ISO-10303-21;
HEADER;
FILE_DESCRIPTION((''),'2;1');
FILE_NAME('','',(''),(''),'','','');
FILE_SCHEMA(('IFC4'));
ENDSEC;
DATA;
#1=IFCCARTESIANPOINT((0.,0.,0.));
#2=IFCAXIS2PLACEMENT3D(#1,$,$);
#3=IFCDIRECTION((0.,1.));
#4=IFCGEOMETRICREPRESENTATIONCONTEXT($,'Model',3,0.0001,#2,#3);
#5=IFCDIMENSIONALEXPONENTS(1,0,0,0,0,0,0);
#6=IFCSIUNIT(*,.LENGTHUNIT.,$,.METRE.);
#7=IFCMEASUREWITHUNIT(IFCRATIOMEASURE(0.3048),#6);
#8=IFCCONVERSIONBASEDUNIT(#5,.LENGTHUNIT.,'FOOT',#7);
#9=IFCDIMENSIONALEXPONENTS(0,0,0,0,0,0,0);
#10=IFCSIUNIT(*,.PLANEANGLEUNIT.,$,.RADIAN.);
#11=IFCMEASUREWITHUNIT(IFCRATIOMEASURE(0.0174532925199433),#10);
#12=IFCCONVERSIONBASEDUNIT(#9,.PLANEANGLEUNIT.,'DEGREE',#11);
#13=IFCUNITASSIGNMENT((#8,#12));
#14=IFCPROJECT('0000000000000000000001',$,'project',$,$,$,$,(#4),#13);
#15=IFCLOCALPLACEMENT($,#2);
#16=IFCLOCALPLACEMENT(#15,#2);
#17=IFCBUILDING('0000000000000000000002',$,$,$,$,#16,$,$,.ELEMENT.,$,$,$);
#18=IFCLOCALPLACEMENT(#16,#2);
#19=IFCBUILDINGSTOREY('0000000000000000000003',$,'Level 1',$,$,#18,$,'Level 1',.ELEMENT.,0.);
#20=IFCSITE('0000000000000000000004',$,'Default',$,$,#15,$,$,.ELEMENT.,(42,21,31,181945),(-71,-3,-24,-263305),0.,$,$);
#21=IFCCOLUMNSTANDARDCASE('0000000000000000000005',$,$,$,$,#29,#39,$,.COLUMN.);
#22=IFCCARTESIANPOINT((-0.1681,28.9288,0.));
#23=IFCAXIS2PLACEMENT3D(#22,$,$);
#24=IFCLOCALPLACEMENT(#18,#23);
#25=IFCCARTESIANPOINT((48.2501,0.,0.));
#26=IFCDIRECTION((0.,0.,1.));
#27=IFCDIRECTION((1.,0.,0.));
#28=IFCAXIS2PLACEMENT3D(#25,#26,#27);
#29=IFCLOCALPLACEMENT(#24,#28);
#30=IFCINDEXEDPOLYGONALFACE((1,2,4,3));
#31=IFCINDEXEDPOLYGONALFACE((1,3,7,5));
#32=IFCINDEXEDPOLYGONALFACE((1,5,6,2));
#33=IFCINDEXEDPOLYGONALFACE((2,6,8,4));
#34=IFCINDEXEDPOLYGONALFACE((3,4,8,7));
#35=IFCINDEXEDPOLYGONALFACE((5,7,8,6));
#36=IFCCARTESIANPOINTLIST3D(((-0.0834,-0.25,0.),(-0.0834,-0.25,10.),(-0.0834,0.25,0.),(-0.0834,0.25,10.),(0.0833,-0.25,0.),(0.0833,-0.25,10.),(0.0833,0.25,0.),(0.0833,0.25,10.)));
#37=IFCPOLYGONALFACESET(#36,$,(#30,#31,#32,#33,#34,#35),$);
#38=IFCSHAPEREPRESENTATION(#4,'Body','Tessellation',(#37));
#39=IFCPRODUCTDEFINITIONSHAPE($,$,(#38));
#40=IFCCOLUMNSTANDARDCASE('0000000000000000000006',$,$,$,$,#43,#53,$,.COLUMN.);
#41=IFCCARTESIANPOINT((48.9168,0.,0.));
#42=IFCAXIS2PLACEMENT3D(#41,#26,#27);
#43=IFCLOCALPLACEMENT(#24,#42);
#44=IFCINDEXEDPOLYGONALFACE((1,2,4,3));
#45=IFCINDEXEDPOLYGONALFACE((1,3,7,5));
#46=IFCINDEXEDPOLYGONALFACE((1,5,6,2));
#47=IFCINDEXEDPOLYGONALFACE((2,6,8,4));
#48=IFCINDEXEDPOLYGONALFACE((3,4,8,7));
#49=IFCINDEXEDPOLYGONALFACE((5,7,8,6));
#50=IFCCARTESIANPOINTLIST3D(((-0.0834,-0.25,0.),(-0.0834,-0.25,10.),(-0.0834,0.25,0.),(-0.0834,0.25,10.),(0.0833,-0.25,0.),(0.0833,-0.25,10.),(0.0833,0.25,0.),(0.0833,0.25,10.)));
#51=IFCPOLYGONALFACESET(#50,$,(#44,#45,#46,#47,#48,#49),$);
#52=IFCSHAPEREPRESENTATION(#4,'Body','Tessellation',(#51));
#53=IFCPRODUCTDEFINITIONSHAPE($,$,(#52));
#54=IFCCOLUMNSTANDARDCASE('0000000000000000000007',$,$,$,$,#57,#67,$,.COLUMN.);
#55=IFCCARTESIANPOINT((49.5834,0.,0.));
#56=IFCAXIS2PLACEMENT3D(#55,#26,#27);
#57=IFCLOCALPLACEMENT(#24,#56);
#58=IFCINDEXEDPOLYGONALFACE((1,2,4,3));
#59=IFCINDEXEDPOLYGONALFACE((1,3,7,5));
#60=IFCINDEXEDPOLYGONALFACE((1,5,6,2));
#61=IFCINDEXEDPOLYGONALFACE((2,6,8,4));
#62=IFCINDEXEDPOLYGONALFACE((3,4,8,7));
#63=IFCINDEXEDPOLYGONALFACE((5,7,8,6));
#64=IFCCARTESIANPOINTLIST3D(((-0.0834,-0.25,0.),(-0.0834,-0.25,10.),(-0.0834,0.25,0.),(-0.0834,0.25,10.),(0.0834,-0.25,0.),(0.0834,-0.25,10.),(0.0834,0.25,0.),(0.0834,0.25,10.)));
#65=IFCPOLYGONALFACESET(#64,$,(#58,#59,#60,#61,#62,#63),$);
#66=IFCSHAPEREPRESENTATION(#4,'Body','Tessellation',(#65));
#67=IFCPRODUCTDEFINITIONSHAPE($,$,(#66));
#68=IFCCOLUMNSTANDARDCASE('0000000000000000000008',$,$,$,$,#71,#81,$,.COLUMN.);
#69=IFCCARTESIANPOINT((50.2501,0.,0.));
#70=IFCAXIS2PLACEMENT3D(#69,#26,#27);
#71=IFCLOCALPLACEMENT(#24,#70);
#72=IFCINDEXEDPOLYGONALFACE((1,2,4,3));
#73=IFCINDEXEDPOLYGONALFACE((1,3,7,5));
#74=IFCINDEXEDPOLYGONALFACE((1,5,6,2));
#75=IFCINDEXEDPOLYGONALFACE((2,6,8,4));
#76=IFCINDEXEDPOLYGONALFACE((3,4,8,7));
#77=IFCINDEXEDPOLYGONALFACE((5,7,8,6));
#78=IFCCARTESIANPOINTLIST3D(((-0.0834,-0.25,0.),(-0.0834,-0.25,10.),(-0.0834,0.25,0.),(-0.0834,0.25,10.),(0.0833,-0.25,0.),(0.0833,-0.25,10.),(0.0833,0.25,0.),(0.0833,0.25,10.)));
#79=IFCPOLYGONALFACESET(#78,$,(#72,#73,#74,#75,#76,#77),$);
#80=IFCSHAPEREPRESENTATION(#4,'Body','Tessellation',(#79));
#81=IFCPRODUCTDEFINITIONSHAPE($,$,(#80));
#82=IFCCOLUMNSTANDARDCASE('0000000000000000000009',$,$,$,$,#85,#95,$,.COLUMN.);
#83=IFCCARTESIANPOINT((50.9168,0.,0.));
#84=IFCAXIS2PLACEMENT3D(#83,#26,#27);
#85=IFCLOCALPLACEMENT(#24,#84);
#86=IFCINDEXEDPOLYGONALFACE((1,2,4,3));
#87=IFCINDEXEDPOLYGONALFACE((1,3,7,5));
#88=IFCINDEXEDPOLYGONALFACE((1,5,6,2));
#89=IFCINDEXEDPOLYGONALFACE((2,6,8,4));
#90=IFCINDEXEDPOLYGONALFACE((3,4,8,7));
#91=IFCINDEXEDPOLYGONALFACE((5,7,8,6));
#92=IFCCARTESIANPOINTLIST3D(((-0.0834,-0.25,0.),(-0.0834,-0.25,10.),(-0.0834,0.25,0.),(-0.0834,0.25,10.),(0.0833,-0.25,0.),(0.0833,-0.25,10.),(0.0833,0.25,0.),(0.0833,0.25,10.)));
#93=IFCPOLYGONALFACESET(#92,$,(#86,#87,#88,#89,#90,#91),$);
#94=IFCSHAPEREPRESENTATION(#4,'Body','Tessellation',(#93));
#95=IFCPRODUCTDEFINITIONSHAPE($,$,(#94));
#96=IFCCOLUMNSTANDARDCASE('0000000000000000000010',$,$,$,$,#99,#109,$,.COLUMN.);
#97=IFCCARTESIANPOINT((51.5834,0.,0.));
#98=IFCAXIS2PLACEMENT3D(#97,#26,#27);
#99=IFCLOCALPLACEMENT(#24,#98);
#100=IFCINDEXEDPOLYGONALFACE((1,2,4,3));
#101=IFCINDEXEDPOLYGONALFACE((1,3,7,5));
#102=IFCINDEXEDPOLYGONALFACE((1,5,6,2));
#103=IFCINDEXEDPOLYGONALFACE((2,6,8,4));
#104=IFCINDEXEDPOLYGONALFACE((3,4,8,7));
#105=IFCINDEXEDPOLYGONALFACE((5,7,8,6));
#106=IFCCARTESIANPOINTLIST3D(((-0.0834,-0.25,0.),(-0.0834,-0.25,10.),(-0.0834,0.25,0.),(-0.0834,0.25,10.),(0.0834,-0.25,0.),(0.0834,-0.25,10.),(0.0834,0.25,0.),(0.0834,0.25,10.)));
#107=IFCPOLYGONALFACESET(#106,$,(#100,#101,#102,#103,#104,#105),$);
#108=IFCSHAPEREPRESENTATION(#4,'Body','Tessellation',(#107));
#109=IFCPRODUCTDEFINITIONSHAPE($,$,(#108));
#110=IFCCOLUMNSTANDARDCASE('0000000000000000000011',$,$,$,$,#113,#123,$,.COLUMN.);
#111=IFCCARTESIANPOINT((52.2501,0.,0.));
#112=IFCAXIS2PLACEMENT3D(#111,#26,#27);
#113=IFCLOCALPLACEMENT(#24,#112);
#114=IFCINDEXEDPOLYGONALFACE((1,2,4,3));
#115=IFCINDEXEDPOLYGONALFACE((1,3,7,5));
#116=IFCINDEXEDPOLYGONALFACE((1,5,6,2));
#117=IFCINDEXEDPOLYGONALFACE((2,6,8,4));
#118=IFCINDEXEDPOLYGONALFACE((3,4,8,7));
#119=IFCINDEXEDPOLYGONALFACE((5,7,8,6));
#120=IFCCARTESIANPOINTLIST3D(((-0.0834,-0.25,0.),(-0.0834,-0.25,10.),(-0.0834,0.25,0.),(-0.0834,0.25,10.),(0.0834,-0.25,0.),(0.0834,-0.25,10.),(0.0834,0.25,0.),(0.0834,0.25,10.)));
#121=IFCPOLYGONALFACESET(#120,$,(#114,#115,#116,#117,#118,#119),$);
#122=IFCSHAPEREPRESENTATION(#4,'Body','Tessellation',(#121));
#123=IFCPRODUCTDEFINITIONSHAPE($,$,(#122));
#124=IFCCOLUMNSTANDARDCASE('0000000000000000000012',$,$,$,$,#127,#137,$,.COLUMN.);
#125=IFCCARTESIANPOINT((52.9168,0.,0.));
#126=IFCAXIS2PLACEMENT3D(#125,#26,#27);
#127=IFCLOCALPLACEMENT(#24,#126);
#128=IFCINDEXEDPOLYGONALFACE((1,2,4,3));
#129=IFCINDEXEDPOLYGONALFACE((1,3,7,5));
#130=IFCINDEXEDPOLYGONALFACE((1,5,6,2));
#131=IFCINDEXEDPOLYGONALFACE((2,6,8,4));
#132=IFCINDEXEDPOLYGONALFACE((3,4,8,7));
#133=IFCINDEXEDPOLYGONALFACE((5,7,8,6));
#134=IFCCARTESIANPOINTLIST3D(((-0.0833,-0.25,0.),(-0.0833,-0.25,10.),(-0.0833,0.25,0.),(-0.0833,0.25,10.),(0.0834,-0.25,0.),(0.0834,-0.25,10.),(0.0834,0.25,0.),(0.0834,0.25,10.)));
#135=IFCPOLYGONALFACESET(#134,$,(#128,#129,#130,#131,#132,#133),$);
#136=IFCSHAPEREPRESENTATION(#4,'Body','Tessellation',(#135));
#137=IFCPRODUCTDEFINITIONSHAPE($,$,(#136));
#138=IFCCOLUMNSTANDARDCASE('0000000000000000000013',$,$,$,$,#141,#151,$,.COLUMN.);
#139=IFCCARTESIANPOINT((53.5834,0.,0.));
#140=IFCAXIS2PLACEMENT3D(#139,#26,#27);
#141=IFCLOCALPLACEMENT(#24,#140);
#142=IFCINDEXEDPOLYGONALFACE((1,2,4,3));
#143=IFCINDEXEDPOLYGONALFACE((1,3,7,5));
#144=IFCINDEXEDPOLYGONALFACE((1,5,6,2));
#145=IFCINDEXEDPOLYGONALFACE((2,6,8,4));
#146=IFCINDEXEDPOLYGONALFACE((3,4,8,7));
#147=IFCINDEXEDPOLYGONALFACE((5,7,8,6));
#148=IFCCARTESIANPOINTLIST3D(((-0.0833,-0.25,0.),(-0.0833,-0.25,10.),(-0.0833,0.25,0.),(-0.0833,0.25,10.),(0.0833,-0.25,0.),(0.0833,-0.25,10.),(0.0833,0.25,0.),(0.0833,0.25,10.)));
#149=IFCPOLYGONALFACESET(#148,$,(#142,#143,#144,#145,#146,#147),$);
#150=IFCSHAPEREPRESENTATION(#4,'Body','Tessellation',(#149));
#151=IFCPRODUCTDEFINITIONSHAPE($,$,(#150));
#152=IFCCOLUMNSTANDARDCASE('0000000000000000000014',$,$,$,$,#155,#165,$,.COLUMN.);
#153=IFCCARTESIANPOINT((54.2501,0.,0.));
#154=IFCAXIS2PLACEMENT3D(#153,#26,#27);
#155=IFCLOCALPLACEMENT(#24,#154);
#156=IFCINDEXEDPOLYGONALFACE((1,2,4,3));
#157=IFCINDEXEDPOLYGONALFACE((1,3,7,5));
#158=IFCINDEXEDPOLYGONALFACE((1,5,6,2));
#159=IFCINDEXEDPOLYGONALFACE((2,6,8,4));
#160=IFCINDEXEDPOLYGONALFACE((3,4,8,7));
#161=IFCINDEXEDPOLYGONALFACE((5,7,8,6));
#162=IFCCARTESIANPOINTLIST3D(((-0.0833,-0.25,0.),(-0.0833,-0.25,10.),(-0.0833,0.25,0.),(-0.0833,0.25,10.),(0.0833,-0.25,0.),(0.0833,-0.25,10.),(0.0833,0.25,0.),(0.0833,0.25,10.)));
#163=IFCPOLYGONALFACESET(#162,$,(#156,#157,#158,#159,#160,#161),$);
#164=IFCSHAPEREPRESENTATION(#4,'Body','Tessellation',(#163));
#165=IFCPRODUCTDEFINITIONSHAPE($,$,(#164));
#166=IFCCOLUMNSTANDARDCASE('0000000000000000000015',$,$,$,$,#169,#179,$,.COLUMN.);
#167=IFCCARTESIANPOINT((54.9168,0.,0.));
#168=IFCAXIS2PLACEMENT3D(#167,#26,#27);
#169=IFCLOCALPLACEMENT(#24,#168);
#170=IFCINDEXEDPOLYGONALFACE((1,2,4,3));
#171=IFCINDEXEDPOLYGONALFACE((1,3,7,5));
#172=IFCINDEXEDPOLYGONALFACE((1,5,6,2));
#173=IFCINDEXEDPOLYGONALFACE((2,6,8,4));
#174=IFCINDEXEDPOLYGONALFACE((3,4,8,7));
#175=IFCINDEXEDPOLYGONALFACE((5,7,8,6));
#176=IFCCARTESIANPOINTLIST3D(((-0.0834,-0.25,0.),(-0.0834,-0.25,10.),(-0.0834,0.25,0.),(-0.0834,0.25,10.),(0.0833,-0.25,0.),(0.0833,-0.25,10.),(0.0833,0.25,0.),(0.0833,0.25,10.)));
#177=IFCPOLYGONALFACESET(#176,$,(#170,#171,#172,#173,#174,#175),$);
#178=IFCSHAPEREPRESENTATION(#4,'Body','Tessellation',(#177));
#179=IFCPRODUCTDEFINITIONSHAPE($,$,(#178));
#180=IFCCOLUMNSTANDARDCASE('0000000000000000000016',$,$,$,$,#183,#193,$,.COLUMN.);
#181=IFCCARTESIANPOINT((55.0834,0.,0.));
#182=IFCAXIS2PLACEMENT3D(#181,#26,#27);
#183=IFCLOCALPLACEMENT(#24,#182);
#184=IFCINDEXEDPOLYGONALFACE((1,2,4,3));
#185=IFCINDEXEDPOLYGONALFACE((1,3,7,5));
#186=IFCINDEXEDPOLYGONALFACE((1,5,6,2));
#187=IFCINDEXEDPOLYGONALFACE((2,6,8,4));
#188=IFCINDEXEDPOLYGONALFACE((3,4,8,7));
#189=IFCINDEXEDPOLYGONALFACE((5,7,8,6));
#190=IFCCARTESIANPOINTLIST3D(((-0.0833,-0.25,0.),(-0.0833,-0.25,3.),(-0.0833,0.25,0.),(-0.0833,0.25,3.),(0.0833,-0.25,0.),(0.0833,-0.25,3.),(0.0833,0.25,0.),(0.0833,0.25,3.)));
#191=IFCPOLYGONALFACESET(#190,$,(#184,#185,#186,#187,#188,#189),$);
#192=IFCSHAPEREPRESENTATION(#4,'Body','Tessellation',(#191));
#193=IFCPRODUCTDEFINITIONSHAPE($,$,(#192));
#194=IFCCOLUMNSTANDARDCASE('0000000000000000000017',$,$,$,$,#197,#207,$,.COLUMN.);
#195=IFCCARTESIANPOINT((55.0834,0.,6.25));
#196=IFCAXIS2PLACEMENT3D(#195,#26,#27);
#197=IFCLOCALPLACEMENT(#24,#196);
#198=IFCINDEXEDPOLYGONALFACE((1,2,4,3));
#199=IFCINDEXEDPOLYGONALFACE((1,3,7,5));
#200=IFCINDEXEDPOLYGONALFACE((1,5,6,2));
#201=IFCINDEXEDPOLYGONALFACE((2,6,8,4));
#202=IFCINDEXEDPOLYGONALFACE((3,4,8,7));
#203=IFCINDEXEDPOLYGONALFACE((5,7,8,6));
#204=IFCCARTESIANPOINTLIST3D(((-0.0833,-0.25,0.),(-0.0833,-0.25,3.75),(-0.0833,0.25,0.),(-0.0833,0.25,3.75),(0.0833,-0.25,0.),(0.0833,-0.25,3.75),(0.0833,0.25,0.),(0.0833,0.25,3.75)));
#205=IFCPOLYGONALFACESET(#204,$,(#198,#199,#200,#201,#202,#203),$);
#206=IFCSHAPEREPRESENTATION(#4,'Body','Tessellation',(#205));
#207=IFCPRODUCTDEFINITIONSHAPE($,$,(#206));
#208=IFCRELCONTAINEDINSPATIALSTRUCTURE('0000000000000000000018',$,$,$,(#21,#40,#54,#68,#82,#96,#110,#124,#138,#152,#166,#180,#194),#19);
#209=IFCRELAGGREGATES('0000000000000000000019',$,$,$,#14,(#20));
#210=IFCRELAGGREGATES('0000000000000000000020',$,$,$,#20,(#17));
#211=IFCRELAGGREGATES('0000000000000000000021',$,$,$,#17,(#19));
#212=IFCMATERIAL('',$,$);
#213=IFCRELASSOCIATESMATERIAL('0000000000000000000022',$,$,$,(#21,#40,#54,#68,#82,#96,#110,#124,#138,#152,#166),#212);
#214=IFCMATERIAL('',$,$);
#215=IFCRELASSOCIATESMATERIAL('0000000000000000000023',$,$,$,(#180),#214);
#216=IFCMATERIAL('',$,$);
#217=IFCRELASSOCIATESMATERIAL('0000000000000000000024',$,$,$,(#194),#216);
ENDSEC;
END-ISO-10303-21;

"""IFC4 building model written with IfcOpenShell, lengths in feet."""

from ifc_helpers import new_model, entity, si_unit, converted_unit, direction, frame, origin, place, context, project, spatial, rectangle, extrude, material, element, save


model = new_model("IFC4")

# Units and contexts
model_context = context("Model", 3, precision=0.0001, world=origin(), true_north=direction((0.0, 1.0)))
ifc_project = project(units=[converted_unit("LENGTHUNIT", "FOOT", entity("IfcRatioMeasure", 0.3048), si_unit("LENGTHUNIT", "METRE"), dimensions=[1, 0, 0, 0, 0, 0, 0]), converted_unit("PLANEANGLEUNIT", "DEGREE", entity("IfcRatioMeasure", 0.0174532925199433), si_unit("PLANEANGLEUNIT", "RADIAN"), dimensions=[0, 0, 0, 0, 0, 0, 0])], contexts=[model_context])

# Site, building, storey
site_placement = place(None, origin())
site = spatial("IfcSite", under=ifc_project, at=site_placement, Name="Default", CompositionType="ELEMENT", RefLatitude=(42, 21, 31, 181945), RefLongitude=(-71, -3, -24, -263305), RefElevation=0.0)
building_placement = place(site_placement, origin())
building = spatial("IfcBuilding", under=site, at=building_placement, CompositionType="ELEMENT")
storey_placement = place(building_placement, origin())
storey = spatial("IfcBuildingStorey", under=building, at=storey_placement, Name="Level 1", LongName="Level 1", CompositionType="ELEMENT", Elevation=0.0)

# Columns
ifc_material_1 = material(Name="")
placement = place(storey_placement, frame((-0.1681, 28.9288, 0.0)))
for number, where, z_axis, x_axis in (
    (1, (48.2501, 0.0, 0.0), (0.0, 0.0, 1.0), (1.0, 0.0, 0.0)),
    (2, (48.9168, 0.0, 0.0), (0.0, 0.0, 1.0), (1.0, 0.0, 0.0)),
    (3, (49.5834, 0.0, 0.0), (0.0, 0.0, 1.0), (1.0, 0.0, 0.0)),
    (4, (50.2501, 0.0, 0.0), (0.0, 0.0, 1.0), (1.0, 0.0, 0.0)),
    (5, (50.9168, 0.0, 0.0), (0.0, 0.0, 1.0), (1.0, 0.0, 0.0)),
    (6, (51.5834, 0.0, 0.0), (0.0, 0.0, 1.0), (1.0, 0.0, 0.0)),
    (7, (52.2501, 0.0, 0.0), (0.0, 0.0, 1.0), (1.0, 0.0, 0.0)),
    (8, (52.9168, 0.0, 0.0), (0.0, 0.0, 1.0), (1.0, 0.0, 0.0)),
    (9, (53.5834, 0.0, 0.0), (0.0, 0.0, 1.0), (1.0, 0.0, 0.0)),
    (10, (54.2501, 0.0, 0.0), (0.0, 0.0, 1.0), (1.0, 0.0, 0.0)),
    (11, (54.9168, 0.0, 0.0), (0.0, 0.0, 1.0), (1.0, 0.0, 0.0)),
):
    element("IfcColumnStandardCase", number, at=place(placement, frame(where, z_axis=z_axis, x_axis=x_axis)), inside=storey, material=ifc_material_1, PredefinedType="COLUMN", context=model_context, shape_type="SweptSolid", body=[
        extrude(rectangle(XDim=0.1667, YDim=0.5), origin(), (0.0, 0.0, 1.0), 10.0),
    ])
ifc_material_2 = material(Name="")
for number, where, z_axis, x_axis in (
    (12, (55.0834, 0.0, 0.0), (0.0, 0.0, 1.0), (1.0, 0.0, 0.0)),
):
    element("IfcColumnStandardCase", number, at=place(placement, frame(where, z_axis=z_axis, x_axis=x_axis)), inside=storey, material=ifc_material_2, PredefinedType="COLUMN", context=model_context, shape_type="SweptSolid", body=[
        extrude(rectangle(XDim=0.1667, YDim=0.5), origin(), (0.0, 0.0, 1.0), 3.0),
    ])
ifc_material_3 = material(Name="")
for number, where, z_axis, x_axis in (
    (13, (55.0834, 0.0, 6.25), (0.0, 0.0, 1.0), (1.0, 0.0, 0.0)),
):
    element("IfcColumnStandardCase", number, at=place(placement, frame(where, z_axis=z_axis, x_axis=x_axis)), inside=storey, material=ifc_material_3, PredefinedType="COLUMN", context=model_context, shape_type="SweptSolid", body=[
        extrude(rectangle(XDim=0.1667, YDim=0.5), origin(), (0.0, 0.0, 1.0), 3.75),
    ])

save(model, "model.ifc")
